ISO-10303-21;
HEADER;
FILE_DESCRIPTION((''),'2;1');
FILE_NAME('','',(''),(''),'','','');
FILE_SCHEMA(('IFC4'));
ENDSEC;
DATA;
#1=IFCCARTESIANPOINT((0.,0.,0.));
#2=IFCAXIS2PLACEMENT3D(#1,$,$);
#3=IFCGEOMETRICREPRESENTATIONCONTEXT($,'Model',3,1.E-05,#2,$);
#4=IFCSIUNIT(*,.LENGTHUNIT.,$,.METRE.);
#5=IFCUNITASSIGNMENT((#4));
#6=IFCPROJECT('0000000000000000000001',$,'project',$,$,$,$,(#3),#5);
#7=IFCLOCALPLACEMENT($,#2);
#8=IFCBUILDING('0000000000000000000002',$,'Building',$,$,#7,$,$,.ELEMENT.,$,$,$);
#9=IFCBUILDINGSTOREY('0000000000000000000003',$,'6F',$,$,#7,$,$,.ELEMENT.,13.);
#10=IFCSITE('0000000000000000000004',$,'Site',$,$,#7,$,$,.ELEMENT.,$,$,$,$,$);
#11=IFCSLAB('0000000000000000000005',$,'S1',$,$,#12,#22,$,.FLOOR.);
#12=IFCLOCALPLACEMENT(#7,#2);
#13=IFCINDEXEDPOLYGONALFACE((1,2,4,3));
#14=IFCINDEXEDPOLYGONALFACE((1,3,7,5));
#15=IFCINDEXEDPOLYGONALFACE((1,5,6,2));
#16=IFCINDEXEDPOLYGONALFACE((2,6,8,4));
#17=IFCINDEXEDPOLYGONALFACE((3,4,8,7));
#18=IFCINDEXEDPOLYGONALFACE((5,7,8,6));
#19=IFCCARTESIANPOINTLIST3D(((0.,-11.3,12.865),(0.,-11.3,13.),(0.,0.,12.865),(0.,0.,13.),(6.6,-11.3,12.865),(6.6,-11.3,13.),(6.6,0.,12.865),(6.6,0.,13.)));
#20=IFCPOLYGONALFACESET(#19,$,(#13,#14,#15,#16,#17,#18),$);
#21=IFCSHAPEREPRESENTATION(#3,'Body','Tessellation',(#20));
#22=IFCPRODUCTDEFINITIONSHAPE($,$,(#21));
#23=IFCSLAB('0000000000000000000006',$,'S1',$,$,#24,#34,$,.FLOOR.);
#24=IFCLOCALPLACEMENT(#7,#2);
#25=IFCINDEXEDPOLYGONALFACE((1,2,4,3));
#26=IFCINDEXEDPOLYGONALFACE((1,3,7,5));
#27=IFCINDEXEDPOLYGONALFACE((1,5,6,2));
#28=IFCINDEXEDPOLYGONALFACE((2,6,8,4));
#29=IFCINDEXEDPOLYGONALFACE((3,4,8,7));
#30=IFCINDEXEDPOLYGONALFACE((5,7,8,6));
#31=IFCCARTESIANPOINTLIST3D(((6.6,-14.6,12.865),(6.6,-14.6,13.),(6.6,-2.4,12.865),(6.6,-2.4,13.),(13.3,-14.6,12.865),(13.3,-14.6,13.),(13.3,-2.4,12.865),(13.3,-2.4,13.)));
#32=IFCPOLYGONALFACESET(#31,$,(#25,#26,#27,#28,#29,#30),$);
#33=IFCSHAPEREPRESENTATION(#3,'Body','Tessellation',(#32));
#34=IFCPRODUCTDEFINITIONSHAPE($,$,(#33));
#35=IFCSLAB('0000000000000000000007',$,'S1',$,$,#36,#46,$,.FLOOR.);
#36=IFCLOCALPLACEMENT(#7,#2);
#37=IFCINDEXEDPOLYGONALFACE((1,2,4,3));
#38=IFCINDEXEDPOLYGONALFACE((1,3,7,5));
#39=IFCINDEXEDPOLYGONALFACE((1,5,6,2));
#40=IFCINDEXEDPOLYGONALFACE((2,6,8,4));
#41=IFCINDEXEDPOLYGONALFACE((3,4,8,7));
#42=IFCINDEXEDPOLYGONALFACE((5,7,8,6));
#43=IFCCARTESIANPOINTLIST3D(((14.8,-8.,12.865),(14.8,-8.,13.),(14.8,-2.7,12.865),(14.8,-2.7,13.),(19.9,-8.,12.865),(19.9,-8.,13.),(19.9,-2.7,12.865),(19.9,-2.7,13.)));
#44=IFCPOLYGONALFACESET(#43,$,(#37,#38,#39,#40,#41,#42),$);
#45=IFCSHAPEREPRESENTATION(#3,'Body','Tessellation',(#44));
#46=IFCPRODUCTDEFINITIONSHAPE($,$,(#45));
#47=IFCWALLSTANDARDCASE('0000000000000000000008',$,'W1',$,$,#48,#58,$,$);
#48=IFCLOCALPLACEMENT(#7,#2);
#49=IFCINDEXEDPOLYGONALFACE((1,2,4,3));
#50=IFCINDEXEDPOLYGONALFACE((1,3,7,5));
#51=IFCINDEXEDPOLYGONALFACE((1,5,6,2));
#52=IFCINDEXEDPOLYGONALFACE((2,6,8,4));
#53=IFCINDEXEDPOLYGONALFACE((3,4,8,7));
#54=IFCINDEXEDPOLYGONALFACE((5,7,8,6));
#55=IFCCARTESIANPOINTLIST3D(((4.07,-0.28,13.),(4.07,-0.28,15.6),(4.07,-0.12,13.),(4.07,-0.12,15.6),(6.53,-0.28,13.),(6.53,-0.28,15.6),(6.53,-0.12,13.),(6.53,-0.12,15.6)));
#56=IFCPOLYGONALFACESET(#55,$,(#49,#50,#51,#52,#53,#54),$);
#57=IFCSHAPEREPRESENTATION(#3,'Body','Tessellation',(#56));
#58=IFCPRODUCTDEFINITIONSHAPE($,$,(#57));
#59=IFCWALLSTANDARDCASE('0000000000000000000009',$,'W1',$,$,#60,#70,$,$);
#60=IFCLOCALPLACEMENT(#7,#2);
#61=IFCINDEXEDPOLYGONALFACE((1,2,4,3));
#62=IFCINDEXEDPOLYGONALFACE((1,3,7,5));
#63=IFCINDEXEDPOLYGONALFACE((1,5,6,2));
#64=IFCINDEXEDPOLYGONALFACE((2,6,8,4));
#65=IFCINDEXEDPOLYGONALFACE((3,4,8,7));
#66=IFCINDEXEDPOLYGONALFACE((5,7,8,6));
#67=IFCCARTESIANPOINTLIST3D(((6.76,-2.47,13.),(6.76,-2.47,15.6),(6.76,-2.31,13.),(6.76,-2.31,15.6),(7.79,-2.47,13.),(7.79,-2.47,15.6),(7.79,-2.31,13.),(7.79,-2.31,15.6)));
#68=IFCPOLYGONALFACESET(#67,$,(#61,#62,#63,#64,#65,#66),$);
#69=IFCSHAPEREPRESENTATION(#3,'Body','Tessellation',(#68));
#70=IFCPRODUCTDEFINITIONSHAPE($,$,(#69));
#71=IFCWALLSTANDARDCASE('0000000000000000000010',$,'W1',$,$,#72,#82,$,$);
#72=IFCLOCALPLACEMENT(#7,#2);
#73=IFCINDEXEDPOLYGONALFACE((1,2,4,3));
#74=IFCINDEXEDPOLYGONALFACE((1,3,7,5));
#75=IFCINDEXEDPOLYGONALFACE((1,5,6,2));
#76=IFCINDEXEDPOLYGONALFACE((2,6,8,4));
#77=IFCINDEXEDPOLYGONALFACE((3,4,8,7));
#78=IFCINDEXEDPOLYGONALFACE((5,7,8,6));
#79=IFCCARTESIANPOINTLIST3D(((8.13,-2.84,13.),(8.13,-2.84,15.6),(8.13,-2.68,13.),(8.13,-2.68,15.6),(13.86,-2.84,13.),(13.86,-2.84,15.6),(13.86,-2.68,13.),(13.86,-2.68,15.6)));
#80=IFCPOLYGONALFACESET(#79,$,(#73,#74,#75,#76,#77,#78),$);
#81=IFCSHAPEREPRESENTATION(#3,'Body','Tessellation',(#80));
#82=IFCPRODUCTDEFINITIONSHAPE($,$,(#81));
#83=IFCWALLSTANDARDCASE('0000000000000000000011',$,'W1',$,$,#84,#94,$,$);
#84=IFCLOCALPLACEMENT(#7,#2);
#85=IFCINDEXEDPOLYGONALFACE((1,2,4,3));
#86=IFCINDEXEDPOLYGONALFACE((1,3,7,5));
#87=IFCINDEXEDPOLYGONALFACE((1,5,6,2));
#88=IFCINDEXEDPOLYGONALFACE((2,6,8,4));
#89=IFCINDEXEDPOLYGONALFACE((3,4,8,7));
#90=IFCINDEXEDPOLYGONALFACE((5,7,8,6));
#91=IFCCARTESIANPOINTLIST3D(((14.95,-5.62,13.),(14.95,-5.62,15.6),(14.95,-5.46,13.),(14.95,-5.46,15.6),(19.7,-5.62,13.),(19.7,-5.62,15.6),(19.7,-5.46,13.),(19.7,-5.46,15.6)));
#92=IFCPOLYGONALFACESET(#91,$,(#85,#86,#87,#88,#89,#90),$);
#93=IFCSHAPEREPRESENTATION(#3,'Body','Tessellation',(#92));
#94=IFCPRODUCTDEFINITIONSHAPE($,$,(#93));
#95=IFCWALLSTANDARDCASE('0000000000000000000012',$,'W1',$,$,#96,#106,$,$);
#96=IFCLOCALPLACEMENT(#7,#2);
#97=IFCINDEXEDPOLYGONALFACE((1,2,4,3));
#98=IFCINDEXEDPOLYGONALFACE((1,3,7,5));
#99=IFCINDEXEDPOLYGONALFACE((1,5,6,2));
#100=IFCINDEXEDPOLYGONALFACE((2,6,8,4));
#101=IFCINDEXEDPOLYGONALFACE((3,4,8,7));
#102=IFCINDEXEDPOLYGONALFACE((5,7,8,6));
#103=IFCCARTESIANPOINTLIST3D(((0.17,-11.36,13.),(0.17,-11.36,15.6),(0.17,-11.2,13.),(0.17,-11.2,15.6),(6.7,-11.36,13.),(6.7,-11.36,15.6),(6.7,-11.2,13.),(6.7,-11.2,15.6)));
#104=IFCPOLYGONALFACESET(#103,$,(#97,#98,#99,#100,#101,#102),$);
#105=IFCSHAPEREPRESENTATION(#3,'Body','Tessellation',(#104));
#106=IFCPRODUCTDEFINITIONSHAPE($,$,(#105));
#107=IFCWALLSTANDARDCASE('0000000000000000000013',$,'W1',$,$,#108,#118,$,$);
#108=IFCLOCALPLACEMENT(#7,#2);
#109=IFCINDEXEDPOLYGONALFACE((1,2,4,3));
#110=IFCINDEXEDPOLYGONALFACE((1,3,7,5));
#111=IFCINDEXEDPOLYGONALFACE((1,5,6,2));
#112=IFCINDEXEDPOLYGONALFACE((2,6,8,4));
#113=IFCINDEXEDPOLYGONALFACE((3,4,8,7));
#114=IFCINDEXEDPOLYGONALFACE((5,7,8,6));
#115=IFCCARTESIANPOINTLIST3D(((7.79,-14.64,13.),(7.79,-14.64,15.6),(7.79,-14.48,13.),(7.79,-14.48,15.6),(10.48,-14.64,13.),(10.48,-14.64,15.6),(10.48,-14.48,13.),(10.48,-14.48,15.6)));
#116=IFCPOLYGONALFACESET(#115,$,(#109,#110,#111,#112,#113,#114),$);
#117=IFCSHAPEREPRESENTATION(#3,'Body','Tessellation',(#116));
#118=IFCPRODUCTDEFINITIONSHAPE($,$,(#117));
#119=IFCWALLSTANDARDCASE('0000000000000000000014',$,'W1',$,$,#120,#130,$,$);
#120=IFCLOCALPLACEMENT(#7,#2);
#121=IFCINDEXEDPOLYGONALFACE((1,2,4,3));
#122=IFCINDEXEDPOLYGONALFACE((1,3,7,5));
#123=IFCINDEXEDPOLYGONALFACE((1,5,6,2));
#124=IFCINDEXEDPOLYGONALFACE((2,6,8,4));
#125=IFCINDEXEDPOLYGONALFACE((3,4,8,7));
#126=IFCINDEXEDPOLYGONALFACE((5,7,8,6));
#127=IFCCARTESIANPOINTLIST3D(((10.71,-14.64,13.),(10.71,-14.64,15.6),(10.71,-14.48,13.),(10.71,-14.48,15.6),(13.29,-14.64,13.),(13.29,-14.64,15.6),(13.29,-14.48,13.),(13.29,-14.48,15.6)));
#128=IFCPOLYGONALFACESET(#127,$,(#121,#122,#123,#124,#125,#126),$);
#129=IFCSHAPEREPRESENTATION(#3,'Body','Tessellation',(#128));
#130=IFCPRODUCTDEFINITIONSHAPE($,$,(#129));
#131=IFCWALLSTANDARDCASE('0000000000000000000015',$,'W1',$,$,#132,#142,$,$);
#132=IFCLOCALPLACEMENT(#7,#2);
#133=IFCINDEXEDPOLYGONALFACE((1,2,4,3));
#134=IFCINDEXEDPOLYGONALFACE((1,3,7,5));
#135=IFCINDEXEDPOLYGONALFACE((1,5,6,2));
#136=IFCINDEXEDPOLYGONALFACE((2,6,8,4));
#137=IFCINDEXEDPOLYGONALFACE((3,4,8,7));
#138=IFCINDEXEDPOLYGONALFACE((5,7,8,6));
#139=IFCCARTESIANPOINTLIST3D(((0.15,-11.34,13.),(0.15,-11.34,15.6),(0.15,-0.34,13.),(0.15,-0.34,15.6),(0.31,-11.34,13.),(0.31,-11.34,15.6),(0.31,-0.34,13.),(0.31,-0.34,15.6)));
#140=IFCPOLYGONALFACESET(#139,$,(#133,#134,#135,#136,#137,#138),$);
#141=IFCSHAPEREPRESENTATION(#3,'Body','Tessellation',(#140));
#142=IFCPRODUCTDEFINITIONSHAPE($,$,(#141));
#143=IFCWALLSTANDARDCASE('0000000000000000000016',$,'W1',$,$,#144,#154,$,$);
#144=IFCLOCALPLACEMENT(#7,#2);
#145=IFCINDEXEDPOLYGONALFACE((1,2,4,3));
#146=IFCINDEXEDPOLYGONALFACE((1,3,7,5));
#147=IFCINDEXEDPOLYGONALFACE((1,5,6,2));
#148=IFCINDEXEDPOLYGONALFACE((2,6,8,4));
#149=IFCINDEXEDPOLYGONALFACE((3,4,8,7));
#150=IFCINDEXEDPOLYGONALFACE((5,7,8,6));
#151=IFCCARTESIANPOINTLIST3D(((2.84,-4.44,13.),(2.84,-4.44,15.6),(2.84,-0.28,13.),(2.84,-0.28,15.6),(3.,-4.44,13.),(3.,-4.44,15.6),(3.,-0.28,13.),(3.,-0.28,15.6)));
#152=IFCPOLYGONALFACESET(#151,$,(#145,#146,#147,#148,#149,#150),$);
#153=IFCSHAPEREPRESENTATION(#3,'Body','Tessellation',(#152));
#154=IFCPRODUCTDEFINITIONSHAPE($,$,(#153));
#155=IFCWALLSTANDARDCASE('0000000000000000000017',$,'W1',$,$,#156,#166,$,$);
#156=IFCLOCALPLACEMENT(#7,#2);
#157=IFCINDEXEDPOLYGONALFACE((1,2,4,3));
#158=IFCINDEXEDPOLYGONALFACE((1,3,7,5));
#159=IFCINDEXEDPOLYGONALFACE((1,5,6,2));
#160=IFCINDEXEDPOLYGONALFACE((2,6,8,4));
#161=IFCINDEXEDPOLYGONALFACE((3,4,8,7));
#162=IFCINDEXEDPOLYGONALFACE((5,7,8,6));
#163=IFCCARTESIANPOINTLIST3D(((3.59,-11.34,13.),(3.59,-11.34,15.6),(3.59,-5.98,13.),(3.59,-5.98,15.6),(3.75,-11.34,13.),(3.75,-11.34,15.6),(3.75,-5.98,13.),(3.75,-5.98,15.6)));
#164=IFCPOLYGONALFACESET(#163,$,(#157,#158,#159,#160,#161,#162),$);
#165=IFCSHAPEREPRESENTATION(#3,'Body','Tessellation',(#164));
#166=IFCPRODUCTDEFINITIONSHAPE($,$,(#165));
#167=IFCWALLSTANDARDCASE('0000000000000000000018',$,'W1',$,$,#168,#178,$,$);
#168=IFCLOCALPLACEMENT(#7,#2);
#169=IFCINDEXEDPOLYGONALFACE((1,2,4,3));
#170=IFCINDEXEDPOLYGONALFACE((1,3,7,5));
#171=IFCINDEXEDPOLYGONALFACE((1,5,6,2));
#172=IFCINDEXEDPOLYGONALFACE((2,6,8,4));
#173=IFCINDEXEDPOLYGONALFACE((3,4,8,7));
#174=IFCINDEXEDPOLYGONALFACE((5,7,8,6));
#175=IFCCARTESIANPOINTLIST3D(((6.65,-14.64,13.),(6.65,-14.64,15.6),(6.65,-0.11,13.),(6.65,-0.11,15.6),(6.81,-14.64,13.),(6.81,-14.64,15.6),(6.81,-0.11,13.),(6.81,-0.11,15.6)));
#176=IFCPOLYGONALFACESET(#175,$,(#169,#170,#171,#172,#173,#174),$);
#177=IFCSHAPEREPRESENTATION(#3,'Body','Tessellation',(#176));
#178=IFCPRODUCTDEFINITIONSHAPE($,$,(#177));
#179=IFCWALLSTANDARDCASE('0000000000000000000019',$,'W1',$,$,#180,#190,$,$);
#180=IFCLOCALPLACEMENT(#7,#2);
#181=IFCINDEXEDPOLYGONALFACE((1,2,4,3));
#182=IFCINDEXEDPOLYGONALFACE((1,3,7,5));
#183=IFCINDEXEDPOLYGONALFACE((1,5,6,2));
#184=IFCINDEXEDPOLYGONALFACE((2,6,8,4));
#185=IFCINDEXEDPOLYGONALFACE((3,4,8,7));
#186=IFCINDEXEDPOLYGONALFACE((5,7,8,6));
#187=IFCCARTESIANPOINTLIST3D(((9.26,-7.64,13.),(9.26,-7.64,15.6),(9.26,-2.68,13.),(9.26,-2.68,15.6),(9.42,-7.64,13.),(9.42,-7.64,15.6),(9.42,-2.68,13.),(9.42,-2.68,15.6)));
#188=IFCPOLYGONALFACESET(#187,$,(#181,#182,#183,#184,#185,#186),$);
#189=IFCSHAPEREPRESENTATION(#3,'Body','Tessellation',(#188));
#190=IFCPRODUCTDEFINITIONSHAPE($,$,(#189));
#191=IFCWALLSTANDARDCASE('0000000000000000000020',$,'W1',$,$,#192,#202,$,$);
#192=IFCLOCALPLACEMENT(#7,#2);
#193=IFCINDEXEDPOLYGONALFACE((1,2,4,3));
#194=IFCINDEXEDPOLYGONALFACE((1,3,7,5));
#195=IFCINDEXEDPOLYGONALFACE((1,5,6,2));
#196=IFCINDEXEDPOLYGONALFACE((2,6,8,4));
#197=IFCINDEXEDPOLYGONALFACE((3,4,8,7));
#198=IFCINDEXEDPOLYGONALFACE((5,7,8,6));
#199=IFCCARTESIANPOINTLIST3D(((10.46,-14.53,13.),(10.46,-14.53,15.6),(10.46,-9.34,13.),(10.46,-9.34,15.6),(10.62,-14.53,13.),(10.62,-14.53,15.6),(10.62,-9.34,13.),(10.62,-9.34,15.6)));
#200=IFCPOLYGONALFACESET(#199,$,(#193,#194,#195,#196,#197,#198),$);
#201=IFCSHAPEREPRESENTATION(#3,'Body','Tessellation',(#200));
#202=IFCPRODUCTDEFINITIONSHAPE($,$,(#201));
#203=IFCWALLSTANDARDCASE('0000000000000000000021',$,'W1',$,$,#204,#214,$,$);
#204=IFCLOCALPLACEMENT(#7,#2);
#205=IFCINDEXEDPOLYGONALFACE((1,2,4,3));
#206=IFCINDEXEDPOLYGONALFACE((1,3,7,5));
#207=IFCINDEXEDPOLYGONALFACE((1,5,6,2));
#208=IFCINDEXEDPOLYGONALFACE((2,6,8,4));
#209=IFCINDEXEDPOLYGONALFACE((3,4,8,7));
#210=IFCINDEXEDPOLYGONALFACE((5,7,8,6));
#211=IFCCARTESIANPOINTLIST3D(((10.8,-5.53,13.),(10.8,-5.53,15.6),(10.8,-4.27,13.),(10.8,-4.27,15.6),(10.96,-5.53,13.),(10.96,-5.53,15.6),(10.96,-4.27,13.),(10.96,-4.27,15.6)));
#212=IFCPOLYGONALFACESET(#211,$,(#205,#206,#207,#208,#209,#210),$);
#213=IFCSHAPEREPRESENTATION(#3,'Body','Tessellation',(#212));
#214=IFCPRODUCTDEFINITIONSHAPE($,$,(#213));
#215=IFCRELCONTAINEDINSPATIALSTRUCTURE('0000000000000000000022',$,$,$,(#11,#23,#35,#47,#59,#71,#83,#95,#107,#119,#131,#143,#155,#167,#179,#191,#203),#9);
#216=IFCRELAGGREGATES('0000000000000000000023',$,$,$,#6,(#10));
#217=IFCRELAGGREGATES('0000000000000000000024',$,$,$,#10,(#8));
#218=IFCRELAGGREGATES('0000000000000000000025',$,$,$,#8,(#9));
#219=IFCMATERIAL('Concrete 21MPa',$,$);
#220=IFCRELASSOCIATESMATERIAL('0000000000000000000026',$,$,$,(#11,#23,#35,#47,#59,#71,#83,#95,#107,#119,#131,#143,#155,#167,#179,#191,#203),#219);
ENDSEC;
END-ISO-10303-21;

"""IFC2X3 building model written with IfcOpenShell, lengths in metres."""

from ifc_helpers import new_model, si_unit, frame, origin, origin_2d, place, context, project, spatial, rectangle, extrude, material, element, save


model = new_model("IFC2X3")

# Units and contexts
model_context = context("Model", 3, precision=1e-05, world=origin())
ifc_project = project(units=[si_unit("LENGTHUNIT", "METRE")], contexts=[model_context])

# Site, building, storey
placement = place(None, origin())
site = spatial("IfcSite", under=ifc_project, at=placement, Name="Site", CompositionType="ELEMENT")
building = spatial("IfcBuilding", under=site, at=placement, Name="Building", CompositionType="ELEMENT")
storey = spatial("IfcBuildingStorey", under=building, at=placement, Name="6F", CompositionType="ELEMENT", Elevation=13.0)

# Slabs
ifc_material_1 = material(Name="Concrete 21MPa")
slab_1_placement = place(None, frame((3.3, -5.65, 12.865)))
element("IfcSlab", 1, at=slab_1_placement, inside=storey, material=ifc_material_1, Name="S1", PredefinedType="FLOOR", context=model_context, shape_type="SweptSolid", body=[
    extrude(rectangle(XDim=6.6, YDim=11.3, at=origin_2d()), origin(), (0.0, 0.0, 1.0), 0.135),
])
slab_2_placement = place(None, frame((9.95, -8.5, 12.865)))
element("IfcSlab", 2, at=slab_2_placement, inside=storey, material=ifc_material_1, Name="S1", PredefinedType="FLOOR", context=model_context, shape_type="SweptSolid", body=[
    extrude(rectangle(XDim=6.7, YDim=12.2, at=origin_2d()), origin(), (0.0, 0.0, 1.0), 0.135),
])
slab_3_placement = place(None, frame((17.35, -5.35, 12.865)))
element("IfcSlab", 3, at=slab_3_placement, inside=storey, material=ifc_material_1, Name="S1", PredefinedType="FLOOR", context=model_context, shape_type="SweptSolid", body=[
    extrude(rectangle(XDim=5.1, YDim=5.3, at=origin_2d()), origin(), (0.0, 0.0, 1.0), 0.135),
])

# Walls
wall_1_placement = place(None, frame((5.3, -0.2, 13.0)))
element("IfcWallStandardCase", 4, at=wall_1_placement, inside=storey, material=ifc_material_1, Name="W1", context=model_context, shape_type="SweptSolid", body=[
    extrude(rectangle(XDim=2.46, YDim=0.16, at=origin_2d()), origin(), (0.0, 0.0, 1.0), 2.6),
])
wall_2_placement = place(None, frame((7.275, -2.39, 13.0)))
element("IfcWallStandardCase", 5, at=wall_2_placement, inside=storey, material=ifc_material_1, Name="W1", context=model_context, shape_type="SweptSolid", body=[
    extrude(rectangle(XDim=1.03, YDim=0.16, at=origin_2d()), origin(), (0.0, 0.0, 1.0), 2.6),
])
wall_3_placement = place(None, frame((10.995, -2.76, 13.0)))
element("IfcWallStandardCase", 6, at=wall_3_placement, inside=storey, material=ifc_material_1, Name="W1", context=model_context, shape_type="SweptSolid", body=[
    extrude(rectangle(XDim=5.73, YDim=0.16, at=origin_2d()), origin(), (0.0, 0.0, 1.0), 2.6),
])
wall_4_placement = place(None, frame((17.325, -5.54, 13.0)))
element("IfcWallStandardCase", 7, at=wall_4_placement, inside=storey, material=ifc_material_1, Name="W1", context=model_context, shape_type="SweptSolid", body=[
    extrude(rectangle(XDim=4.75, YDim=0.16, at=origin_2d()), origin(), (0.0, 0.0, 1.0), 2.6),
])
wall_5_placement = place(None, frame((3.435, -11.28, 13.0)))
element("IfcWallStandardCase", 8, at=wall_5_placement, inside=storey, material=ifc_material_1, Name="W1", context=model_context, shape_type="SweptSolid", body=[
    extrude(rectangle(XDim=6.53, YDim=0.16, at=origin_2d()), origin(), (0.0, 0.0, 1.0), 2.6),
])
wall_6_placement = place(None, frame((9.135, -14.56, 13.0)))
element("IfcWallStandardCase", 9, at=wall_6_placement, inside=storey, material=ifc_material_1, Name="W1", context=model_context, shape_type="SweptSolid", body=[
    extrude(rectangle(XDim=2.69, YDim=0.16, at=origin_2d()), origin(), (0.0, 0.0, 1.0), 2.6),
])
wall_7_placement = place(None, frame((12.0, -14.56, 13.0)))
element("IfcWallStandardCase", 10, at=wall_7_placement, inside=storey, material=ifc_material_1, Name="W1", context=model_context, shape_type="SweptSolid", body=[
    extrude(rectangle(XDim=2.58, YDim=0.16, at=origin_2d()), origin(), (0.0, 0.0, 1.0), 2.6),
])
wall_8_placement = place(None, frame((0.23, -5.84, 13.0)))
element("IfcWallStandardCase", 11, at=wall_8_placement, inside=storey, material=ifc_material_1, Name="W1", context=model_context, shape_type="SweptSolid", body=[
    extrude(rectangle(XDim=0.16, YDim=11.0, at=origin_2d()), origin(), (0.0, 0.0, 1.0), 2.6),
])
wall_9_placement = place(None, frame((2.92, -2.36, 13.0)))
element("IfcWallStandardCase", 12, at=wall_9_placement, inside=storey, material=ifc_material_1, Name="W1", context=model_context, shape_type="SweptSolid", body=[
    extrude(rectangle(XDim=0.16, YDim=4.16, at=origin_2d()), origin(), (0.0, 0.0, 1.0), 2.6),
])
wall_10_placement = place(None, frame((3.67, -8.66, 13.0)))
element("IfcWallStandardCase", 13, at=wall_10_placement, inside=storey, material=ifc_material_1, Name="W1", context=model_context, shape_type="SweptSolid", body=[
    extrude(rectangle(XDim=0.16, YDim=5.36, at=origin_2d()), origin(), (0.0, 0.0, 1.0), 2.6),
])
wall_11_placement = place(None, frame((6.73, -7.375, 13.0)))
element("IfcWallStandardCase", 14, at=wall_11_placement, inside=storey, material=ifc_material_1, Name="W1", context=model_context, shape_type="SweptSolid", body=[
    extrude(rectangle(XDim=0.16, YDim=14.53, at=origin_2d()), origin(), (0.0, 0.0, 1.0), 2.6),
])
wall_12_placement = place(None, frame((9.34, -5.16, 13.0)))
element("IfcWallStandardCase", 15, at=wall_12_placement, inside=storey, material=ifc_material_1, Name="W1", context=model_context, shape_type="SweptSolid", body=[
    extrude(rectangle(XDim=0.16, YDim=4.96, at=origin_2d()), origin(), (0.0, 0.0, 1.0), 2.6),
])
wall_13_placement = place(None, frame((10.54, -11.935, 13.0)))
element("IfcWallStandardCase", 16, at=wall_13_placement, inside=storey, material=ifc_material_1, Name="W1", context=model_context, shape_type="SweptSolid", body=[
    extrude(rectangle(XDim=0.16, YDim=5.19, at=origin_2d()), origin(), (0.0, 0.0, 1.0), 2.6),
])
wall_14_placement = place(None, frame((10.88, -4.9, 13.0)))
element("IfcWallStandardCase", 17, at=wall_14_placement, inside=storey, material=ifc_material_1, Name="W1", context=model_context, shape_type="SweptSolid", body=[
    extrude(rectangle(XDim=0.16, YDim=1.26, at=origin_2d()), origin(), (0.0, 0.0, 1.0), 2.6),
])

save(model, "model.ifc")
